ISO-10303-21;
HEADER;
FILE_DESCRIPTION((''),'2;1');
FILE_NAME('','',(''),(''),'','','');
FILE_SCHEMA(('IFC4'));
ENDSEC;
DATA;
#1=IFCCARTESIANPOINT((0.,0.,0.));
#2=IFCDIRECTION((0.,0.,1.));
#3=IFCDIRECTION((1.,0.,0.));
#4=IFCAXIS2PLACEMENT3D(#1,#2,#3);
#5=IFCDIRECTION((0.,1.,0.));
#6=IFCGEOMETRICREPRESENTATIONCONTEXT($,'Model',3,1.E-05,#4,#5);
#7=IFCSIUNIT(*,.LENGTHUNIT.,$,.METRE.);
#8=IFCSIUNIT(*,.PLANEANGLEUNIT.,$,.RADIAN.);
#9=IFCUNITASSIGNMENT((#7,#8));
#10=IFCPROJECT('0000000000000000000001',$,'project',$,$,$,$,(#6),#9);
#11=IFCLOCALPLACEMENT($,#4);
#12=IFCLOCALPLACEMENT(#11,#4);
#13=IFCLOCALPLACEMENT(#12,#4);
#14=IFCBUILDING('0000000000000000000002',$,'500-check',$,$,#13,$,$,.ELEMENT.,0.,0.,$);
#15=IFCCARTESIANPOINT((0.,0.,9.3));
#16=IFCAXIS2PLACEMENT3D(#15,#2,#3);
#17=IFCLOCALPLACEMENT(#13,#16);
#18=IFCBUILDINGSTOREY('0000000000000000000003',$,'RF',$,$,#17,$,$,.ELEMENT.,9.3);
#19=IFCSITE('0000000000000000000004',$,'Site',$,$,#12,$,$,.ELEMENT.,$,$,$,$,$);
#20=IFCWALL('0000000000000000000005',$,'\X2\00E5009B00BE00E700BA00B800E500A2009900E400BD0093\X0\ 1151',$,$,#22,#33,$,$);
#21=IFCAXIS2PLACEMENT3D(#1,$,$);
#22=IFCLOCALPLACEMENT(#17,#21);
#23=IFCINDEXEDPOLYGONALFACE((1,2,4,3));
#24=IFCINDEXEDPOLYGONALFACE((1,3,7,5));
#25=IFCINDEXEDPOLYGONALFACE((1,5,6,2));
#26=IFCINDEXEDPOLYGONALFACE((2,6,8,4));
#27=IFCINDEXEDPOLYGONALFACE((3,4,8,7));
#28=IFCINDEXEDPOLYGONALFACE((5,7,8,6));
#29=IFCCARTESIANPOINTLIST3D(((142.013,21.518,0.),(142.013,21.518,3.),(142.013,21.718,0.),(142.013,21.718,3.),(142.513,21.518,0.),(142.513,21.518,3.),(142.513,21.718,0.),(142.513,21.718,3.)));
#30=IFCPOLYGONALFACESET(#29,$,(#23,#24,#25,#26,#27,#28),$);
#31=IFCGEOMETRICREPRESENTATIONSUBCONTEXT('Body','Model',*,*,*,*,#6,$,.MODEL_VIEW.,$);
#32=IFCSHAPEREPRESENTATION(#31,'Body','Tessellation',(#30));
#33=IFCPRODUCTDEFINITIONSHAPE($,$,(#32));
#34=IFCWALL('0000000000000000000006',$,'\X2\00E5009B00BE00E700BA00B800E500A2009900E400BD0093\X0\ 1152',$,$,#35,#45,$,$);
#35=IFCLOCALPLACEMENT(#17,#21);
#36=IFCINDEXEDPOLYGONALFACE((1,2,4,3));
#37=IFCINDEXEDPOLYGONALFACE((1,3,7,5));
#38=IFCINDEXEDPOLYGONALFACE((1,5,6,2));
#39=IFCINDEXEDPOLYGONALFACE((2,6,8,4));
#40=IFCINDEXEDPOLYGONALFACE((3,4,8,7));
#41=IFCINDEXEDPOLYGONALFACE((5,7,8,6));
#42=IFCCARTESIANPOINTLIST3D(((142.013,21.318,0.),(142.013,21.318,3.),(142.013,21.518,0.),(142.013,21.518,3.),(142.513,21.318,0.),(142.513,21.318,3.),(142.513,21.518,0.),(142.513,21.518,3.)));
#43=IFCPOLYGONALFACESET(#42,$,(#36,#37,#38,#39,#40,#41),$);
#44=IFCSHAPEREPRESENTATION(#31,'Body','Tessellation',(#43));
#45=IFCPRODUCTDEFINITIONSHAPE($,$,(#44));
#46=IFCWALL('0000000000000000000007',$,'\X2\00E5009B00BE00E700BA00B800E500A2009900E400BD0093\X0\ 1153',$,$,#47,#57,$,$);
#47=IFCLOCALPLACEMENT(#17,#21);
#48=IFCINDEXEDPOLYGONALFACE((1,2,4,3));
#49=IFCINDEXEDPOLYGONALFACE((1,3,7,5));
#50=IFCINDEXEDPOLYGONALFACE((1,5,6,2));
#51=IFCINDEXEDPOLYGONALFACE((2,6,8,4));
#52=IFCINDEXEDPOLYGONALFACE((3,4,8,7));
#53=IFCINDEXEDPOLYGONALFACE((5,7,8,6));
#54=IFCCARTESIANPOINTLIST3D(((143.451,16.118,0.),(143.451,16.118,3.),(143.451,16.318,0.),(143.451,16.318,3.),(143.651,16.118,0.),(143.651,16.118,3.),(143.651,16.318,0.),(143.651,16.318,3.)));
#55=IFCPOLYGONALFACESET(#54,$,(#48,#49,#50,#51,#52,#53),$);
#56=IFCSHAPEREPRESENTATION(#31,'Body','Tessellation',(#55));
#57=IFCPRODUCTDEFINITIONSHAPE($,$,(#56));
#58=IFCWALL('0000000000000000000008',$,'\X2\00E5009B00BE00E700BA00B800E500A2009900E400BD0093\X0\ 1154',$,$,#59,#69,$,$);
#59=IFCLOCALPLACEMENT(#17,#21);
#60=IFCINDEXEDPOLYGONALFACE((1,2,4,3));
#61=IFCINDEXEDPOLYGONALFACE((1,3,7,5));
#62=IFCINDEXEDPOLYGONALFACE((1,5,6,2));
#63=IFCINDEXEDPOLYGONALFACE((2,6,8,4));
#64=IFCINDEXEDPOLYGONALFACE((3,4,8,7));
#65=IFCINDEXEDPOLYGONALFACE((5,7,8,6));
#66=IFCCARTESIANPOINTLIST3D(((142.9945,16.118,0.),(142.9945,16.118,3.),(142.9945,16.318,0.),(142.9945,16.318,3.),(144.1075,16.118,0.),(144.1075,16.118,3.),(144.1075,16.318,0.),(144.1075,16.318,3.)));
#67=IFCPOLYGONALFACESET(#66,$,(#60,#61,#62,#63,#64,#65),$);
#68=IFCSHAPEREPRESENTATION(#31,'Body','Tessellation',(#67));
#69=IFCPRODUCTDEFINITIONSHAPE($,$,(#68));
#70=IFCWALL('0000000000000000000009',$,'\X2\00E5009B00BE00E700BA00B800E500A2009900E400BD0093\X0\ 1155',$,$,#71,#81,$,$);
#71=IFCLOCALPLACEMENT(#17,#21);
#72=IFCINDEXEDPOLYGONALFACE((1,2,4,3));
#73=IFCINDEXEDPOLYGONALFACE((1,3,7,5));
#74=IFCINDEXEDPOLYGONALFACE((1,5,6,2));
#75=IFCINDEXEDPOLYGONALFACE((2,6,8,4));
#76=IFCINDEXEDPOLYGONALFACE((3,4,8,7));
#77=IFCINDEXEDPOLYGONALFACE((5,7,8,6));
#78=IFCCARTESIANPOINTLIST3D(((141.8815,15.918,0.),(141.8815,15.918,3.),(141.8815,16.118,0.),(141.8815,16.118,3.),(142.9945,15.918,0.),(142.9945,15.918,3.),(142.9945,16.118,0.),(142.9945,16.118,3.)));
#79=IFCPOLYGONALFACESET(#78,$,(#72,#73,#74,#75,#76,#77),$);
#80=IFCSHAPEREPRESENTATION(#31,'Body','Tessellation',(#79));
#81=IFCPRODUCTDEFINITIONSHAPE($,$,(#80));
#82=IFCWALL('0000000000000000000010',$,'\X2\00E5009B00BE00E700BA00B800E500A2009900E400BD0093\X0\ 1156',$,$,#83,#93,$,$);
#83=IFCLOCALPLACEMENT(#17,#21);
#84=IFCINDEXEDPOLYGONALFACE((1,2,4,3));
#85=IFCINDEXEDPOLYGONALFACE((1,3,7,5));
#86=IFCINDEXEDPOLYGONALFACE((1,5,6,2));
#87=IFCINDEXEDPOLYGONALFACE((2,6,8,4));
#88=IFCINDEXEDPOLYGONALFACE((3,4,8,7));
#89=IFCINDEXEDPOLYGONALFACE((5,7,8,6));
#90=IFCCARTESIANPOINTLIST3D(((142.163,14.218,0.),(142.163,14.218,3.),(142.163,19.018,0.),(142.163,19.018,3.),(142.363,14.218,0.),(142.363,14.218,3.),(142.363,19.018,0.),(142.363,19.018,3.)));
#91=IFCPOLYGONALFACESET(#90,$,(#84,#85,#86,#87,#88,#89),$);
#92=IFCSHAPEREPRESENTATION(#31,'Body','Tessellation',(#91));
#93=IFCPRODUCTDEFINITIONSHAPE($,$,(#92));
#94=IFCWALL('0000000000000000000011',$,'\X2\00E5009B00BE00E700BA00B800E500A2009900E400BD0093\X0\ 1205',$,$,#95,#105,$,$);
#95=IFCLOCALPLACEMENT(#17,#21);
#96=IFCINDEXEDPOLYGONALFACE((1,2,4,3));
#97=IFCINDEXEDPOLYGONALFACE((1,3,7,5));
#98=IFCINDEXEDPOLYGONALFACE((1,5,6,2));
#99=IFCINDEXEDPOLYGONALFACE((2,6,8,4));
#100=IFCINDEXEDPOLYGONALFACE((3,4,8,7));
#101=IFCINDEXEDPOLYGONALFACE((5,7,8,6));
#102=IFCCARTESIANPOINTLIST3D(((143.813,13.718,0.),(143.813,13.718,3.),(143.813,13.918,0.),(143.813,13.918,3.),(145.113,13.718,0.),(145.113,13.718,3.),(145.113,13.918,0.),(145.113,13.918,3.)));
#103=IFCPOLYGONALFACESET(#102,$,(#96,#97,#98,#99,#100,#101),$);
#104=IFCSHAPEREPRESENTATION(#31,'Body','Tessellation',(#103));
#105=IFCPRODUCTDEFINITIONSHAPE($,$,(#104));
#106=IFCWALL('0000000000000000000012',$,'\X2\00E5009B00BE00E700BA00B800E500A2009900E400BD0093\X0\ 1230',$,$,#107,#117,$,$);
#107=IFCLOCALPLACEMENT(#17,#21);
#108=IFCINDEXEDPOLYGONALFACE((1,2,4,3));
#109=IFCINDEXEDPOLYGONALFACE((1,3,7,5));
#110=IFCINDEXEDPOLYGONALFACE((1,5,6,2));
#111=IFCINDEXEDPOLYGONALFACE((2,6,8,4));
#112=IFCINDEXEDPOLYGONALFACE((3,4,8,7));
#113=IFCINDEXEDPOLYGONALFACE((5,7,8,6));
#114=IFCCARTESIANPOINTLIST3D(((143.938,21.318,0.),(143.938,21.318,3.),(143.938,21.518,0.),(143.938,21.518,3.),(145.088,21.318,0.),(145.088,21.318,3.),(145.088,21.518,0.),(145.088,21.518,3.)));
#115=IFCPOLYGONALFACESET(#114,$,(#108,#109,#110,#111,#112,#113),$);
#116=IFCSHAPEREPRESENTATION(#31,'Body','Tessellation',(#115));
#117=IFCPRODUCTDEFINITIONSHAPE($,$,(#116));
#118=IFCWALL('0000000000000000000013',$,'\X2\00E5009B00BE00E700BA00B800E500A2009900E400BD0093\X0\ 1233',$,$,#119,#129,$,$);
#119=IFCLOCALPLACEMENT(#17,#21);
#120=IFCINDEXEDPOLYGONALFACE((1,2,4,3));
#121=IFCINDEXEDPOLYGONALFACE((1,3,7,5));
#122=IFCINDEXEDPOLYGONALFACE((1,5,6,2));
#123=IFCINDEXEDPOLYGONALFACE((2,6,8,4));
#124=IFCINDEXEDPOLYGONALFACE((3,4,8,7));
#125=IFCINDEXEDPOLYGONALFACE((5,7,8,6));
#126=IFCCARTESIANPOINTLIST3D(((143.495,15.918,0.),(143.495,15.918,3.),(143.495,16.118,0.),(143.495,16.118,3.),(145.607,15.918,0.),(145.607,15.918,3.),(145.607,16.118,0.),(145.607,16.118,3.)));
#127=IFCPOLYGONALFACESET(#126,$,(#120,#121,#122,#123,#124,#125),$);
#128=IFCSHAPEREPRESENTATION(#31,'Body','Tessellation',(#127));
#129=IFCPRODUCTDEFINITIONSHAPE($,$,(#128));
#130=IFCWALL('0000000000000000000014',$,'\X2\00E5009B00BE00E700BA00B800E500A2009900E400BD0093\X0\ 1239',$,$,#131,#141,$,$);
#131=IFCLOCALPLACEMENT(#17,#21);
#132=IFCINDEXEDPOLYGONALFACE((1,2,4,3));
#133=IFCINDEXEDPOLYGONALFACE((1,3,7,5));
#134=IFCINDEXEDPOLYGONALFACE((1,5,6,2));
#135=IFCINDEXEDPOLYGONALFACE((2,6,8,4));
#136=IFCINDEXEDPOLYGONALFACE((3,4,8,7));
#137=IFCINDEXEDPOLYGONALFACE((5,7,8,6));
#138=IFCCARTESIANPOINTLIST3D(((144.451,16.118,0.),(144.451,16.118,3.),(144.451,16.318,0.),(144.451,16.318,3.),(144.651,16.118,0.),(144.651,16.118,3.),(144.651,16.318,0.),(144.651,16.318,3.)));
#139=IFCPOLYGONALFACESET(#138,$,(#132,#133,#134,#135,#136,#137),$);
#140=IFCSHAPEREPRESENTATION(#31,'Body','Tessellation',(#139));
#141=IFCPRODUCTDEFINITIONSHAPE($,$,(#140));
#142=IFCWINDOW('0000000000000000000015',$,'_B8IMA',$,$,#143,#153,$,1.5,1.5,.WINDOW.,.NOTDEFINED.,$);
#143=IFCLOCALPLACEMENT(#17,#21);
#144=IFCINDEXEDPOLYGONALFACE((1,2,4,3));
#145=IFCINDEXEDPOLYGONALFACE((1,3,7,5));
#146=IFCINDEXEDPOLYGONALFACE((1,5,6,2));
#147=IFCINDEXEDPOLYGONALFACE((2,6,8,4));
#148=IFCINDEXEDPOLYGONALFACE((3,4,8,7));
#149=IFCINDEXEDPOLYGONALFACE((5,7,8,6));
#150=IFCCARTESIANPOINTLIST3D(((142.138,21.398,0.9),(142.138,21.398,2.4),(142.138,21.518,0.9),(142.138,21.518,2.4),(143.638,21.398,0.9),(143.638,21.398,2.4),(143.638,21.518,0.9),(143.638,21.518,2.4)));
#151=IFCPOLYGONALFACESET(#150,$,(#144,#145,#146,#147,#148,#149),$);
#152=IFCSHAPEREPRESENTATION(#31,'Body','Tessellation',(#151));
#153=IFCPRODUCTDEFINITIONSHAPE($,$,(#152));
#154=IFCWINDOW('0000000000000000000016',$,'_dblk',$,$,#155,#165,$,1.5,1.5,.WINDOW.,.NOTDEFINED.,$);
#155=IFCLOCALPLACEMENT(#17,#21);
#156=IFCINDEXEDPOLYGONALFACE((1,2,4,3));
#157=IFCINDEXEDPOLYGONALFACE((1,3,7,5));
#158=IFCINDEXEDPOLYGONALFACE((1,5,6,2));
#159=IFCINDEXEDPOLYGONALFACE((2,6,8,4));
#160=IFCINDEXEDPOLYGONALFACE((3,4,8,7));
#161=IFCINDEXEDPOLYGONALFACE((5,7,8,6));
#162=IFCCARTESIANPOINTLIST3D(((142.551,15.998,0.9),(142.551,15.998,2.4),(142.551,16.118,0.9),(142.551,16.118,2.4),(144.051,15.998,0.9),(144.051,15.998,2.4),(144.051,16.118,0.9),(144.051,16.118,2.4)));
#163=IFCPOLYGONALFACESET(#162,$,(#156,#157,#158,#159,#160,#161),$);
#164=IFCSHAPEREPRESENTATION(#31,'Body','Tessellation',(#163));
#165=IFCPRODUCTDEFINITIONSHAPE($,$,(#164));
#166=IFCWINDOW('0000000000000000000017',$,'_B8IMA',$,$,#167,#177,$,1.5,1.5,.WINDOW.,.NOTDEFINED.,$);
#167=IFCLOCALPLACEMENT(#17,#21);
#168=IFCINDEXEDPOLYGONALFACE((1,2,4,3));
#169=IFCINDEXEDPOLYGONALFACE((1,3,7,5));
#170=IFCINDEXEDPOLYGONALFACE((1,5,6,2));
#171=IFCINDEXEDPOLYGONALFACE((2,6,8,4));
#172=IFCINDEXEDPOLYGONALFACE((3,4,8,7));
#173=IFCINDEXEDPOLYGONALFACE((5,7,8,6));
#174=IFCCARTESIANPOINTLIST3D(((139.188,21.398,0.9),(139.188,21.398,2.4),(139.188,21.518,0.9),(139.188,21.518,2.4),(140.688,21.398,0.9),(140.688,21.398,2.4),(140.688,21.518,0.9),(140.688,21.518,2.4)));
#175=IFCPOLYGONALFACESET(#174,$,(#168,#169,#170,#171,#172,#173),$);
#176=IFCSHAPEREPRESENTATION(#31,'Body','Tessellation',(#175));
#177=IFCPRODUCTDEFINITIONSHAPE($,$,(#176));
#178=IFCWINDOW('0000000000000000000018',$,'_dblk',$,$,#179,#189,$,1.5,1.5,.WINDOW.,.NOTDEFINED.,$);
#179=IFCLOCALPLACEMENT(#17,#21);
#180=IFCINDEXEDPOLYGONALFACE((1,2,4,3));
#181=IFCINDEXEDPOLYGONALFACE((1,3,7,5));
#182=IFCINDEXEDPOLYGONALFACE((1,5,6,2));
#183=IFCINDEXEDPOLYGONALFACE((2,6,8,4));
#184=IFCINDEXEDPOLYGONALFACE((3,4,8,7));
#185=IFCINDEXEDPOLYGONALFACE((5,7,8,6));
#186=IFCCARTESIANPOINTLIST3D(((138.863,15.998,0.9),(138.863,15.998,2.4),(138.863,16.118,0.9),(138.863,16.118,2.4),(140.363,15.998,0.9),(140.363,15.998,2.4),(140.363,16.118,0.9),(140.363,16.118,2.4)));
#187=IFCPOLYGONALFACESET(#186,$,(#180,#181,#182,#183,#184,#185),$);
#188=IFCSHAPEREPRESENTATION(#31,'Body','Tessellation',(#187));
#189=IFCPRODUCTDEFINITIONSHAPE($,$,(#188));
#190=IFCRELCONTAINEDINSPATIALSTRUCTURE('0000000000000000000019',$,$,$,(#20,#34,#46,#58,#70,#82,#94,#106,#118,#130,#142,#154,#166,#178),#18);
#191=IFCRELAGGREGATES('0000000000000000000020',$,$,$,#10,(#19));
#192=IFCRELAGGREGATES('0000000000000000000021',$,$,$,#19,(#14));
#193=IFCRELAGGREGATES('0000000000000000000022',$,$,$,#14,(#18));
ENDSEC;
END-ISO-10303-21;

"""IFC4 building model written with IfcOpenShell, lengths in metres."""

from ifc_helpers import new_model, si_unit, direction, frame, frame_2d, origin_with_axes, place, context, subcontext, project, spatial, rectangle, extrude, element, save


model = new_model("IFC4")

# Units and contexts
model_context = context("Model", 3, precision=1e-05, world=origin_with_axes(), true_north=direction((0.0, 1.0, 0.0)))
body_context = subcontext(model_context, "Body", "Model", "MODEL_VIEW")
ifc_project = project(units=[si_unit("LENGTHUNIT", "METRE"), si_unit("PLANEANGLEUNIT", "RADIAN")], contexts=[model_context])

# Site, building, storey
placement = place(None, origin_with_axes())
site_placement = place(placement, origin_with_axes())
site = spatial("IfcSite", under=ifc_project, at=site_placement, Name="Site", CompositionType="ELEMENT")
building_placement = place(site_placement, origin_with_axes())
building = spatial("IfcBuilding", under=site, at=building_placement, Name="500-check", CompositionType="ELEMENT", ElevationOfRefHeight=0.0, ElevationOfTerrain=0.0)
storey_placement = place(building_placement, frame((0.0, 0.0, 9.3), z_axis=(0.0, 0.0, 1.0), x_axis=(1.0, 0.0, 0.0)))
storey = spatial("IfcBuildingStorey", under=building, at=storey_placement, Name="RF", CompositionType="ELEMENT", Elevation=9.3)

# Walls
for number, where, z_axis, x_axis, name in (
    (1, (142.263, 21.618, 0.0), (0.0, 0.0, 1.0), (1.0, 0.0, 0.0), "å\u009b¾çº¸å¢\u0099ä½\u0093 1151"),
    (2, (142.263, 21.418, 0.0), (0.0, 0.0, 1.0), (1.0, 0.0, 0.0), "å\u009b¾çº¸å¢\u0099ä½\u0093 1152"),
):
    element("IfcWall", number, at=place(storey_placement, frame(where, z_axis=z_axis, x_axis=x_axis)), inside=storey, Name=name, context=body_context, shape_type="SweptSolid", body=[
        extrude(rectangle(XDim=0.5, YDim=0.2, at=frame_2d((0.0, 0.0), x_axis=(1.0, 0.0, 0.0))), frame((0.0, 0.0, 0.0), z_axis=(0.0, 0.0, 1.0)), (0.0, 0.0, 1.0), 3.0),
    ])
wall_1_placement = place(storey_placement, frame((143.551, 16.218, 0.0), z_axis=(0.0, 0.0, 1.0), x_axis=(0.0, -1.0, 0.0)))
element("IfcWall", 3, at=wall_1_placement, inside=storey, Name="å\u009b¾çº¸å¢\u0099ä½\u0093 1153", context=body_context, shape_type="SweptSolid", body=[
    extrude(rectangle(XDim=0.2, YDim=0.2, at=frame_2d((0.0, 0.0), x_axis=(1.0, 0.0, 0.0))), frame((0.0, 0.0, 0.0), z_axis=(0.0, 0.0, 1.0)), (0.0, 0.0, 1.0), 3.0),
])
for number, where, z_axis, x_axis, name in (
    (4, (143.551, 16.218, 0.0), (0.0, 0.0, 1.0), (-1.0, 0.0, 0.0), "å\u009b¾çº¸å¢\u0099ä½\u0093 1154"),
    (5, (142.438, 16.018, 0.0), (0.0, 0.0, 1.0), (1.0, 0.0, 0.0), "å\u009b¾çº¸å¢\u0099ä½\u0093 1155"),
):
    element("IfcWall", number, at=place(storey_placement, frame(where, z_axis=z_axis, x_axis=x_axis)), inside=storey, Name=name, context=body_context, shape_type="SweptSolid", body=[
        extrude(rectangle(XDim=1.113, YDim=0.2, at=frame_2d((0.0, 0.0), x_axis=(1.0, 0.0, 0.0))), frame((0.0, 0.0, 0.0), z_axis=(0.0, 0.0, 1.0)), (0.0, 0.0, 1.0), 3.0),
    ])
wall_2_placement = place(storey_placement, frame((142.263, 16.618, 0.0), z_axis=(0.0, 0.0, 1.0), x_axis=(0.0, 1.0, 0.0)))
element("IfcWall", 6, at=wall_2_placement, inside=storey, Name="å\u009b¾çº¸å¢\u0099ä½\u0093 1156", context=body_context, shape_type="SweptSolid", body=[
    extrude(rectangle(XDim=4.8, YDim=0.2, at=frame_2d((0.0, 0.0), x_axis=(1.0, 0.0, 0.0))), frame((0.0, 0.0, 0.0), z_axis=(0.0, 0.0, 1.0)), (0.0, 0.0, 1.0), 3.0),
])
wall_3_placement = place(storey_placement, frame((144.463, 13.818, 0.0), z_axis=(0.0, 0.0, 1.0), x_axis=(1.0, 0.0, 0.0)))
element("IfcWall", 7, at=wall_3_placement, inside=storey, Name="å\u009b¾çº¸å¢\u0099ä½\u0093 1205", context=body_context, shape_type="SweptSolid", body=[
    extrude(rectangle(XDim=1.3, YDim=0.2, at=frame_2d((0.0, 0.0), x_axis=(1.0, 0.0, 0.0))), frame((0.0, 0.0, 0.0), z_axis=(0.0, 0.0, 1.0)), (0.0, 0.0, 1.0), 3.0),
])
wall_4_placement = place(storey_placement, frame((144.513, 21.418, 0.0), z_axis=(0.0, 0.0, 1.0), x_axis=(1.0, 0.0, 0.0)))
element("IfcWall", 8, at=wall_4_placement, inside=storey, Name="å\u009b¾çº¸å¢\u0099ä½\u0093 1230", context=body_context, shape_type="SweptSolid", body=[
    extrude(rectangle(XDim=1.15, YDim=0.2, at=frame_2d((0.0, 0.0), x_axis=(1.0, 0.0, 0.0))), frame((0.0, 0.0, 0.0), z_axis=(0.0, 0.0, 1.0)), (0.0, 0.0, 1.0), 3.0),
])
wall_5_placement = place(storey_placement, frame((144.551, 16.018, 0.0), z_axis=(0.0, 0.0, 1.0), x_axis=(1.0, 0.0, 0.0)))
element("IfcWall", 9, at=wall_5_placement, inside=storey, Name="å\u009b¾çº¸å¢\u0099ä½\u0093 1233", context=body_context, shape_type="SweptSolid", body=[
    extrude(rectangle(XDim=2.112, YDim=0.2, at=frame_2d((0.0, 0.0), x_axis=(1.0, 0.0, 0.0))), frame((0.0, 0.0, 0.0), z_axis=(0.0, 0.0, 1.0)), (0.0, 0.0, 1.0), 3.0),
])
wall_6_placement = place(storey_placement, frame((144.551, 16.218, 0.0), z_axis=(0.0, 0.0, 1.0), x_axis=(0.0, -1.0, 0.0)))
element("IfcWall", 10, at=wall_6_placement, inside=storey, Name="å\u009b¾çº¸å¢\u0099ä½\u0093 1239", context=body_context, shape_type="SweptSolid", body=[
    extrude(rectangle(XDim=0.2, YDim=0.2, at=frame_2d((0.0, 0.0), x_axis=(1.0, 0.0, 0.0))), frame((0.0, 0.0, 0.0), z_axis=(0.0, 0.0, 1.0)), (0.0, 0.0, 1.0), 3.0),
])

# Windows
for number, where, z_axis, x_axis, name in (
    (11, (142.888, 21.458, 0.9), (0.0, 0.0, 1.0), (1.0, 0.0, 0.0), "_B8IMA"),
    (12, (143.301, 16.058, 0.9), (0.0, 0.0, 1.0), (1.0, 0.0, 0.0), "_dblk"),
    (13, (139.938, 21.458, 0.9), (0.0, 0.0, 1.0), (1.0, 0.0, 0.0), "_B8IMA"),
    (14, (139.613, 16.058, 0.9), (0.0, 0.0, 1.0), (1.0, 0.0, 0.0), "_dblk"),
):
    element("IfcWindow", number, at=place(storey_placement, frame(where, z_axis=z_axis, x_axis=x_axis)), inside=storey, Name=name, OverallHeight=1.5, OverallWidth=1.5, PartitioningType="NOTDEFINED", PredefinedType="WINDOW", context=body_context, shape_type="SweptSolid", body=[
        extrude(rectangle(XDim=1.5, YDim=0.12, at=frame_2d((0.0, 0.0), x_axis=(1.0, 0.0, 0.0))), frame((0.0, 0.0, 0.0), z_axis=(0.0, 0.0, 1.0)), (0.0, 0.0, 1.0), 1.5),
    ])

save(model, "model.ifc")
